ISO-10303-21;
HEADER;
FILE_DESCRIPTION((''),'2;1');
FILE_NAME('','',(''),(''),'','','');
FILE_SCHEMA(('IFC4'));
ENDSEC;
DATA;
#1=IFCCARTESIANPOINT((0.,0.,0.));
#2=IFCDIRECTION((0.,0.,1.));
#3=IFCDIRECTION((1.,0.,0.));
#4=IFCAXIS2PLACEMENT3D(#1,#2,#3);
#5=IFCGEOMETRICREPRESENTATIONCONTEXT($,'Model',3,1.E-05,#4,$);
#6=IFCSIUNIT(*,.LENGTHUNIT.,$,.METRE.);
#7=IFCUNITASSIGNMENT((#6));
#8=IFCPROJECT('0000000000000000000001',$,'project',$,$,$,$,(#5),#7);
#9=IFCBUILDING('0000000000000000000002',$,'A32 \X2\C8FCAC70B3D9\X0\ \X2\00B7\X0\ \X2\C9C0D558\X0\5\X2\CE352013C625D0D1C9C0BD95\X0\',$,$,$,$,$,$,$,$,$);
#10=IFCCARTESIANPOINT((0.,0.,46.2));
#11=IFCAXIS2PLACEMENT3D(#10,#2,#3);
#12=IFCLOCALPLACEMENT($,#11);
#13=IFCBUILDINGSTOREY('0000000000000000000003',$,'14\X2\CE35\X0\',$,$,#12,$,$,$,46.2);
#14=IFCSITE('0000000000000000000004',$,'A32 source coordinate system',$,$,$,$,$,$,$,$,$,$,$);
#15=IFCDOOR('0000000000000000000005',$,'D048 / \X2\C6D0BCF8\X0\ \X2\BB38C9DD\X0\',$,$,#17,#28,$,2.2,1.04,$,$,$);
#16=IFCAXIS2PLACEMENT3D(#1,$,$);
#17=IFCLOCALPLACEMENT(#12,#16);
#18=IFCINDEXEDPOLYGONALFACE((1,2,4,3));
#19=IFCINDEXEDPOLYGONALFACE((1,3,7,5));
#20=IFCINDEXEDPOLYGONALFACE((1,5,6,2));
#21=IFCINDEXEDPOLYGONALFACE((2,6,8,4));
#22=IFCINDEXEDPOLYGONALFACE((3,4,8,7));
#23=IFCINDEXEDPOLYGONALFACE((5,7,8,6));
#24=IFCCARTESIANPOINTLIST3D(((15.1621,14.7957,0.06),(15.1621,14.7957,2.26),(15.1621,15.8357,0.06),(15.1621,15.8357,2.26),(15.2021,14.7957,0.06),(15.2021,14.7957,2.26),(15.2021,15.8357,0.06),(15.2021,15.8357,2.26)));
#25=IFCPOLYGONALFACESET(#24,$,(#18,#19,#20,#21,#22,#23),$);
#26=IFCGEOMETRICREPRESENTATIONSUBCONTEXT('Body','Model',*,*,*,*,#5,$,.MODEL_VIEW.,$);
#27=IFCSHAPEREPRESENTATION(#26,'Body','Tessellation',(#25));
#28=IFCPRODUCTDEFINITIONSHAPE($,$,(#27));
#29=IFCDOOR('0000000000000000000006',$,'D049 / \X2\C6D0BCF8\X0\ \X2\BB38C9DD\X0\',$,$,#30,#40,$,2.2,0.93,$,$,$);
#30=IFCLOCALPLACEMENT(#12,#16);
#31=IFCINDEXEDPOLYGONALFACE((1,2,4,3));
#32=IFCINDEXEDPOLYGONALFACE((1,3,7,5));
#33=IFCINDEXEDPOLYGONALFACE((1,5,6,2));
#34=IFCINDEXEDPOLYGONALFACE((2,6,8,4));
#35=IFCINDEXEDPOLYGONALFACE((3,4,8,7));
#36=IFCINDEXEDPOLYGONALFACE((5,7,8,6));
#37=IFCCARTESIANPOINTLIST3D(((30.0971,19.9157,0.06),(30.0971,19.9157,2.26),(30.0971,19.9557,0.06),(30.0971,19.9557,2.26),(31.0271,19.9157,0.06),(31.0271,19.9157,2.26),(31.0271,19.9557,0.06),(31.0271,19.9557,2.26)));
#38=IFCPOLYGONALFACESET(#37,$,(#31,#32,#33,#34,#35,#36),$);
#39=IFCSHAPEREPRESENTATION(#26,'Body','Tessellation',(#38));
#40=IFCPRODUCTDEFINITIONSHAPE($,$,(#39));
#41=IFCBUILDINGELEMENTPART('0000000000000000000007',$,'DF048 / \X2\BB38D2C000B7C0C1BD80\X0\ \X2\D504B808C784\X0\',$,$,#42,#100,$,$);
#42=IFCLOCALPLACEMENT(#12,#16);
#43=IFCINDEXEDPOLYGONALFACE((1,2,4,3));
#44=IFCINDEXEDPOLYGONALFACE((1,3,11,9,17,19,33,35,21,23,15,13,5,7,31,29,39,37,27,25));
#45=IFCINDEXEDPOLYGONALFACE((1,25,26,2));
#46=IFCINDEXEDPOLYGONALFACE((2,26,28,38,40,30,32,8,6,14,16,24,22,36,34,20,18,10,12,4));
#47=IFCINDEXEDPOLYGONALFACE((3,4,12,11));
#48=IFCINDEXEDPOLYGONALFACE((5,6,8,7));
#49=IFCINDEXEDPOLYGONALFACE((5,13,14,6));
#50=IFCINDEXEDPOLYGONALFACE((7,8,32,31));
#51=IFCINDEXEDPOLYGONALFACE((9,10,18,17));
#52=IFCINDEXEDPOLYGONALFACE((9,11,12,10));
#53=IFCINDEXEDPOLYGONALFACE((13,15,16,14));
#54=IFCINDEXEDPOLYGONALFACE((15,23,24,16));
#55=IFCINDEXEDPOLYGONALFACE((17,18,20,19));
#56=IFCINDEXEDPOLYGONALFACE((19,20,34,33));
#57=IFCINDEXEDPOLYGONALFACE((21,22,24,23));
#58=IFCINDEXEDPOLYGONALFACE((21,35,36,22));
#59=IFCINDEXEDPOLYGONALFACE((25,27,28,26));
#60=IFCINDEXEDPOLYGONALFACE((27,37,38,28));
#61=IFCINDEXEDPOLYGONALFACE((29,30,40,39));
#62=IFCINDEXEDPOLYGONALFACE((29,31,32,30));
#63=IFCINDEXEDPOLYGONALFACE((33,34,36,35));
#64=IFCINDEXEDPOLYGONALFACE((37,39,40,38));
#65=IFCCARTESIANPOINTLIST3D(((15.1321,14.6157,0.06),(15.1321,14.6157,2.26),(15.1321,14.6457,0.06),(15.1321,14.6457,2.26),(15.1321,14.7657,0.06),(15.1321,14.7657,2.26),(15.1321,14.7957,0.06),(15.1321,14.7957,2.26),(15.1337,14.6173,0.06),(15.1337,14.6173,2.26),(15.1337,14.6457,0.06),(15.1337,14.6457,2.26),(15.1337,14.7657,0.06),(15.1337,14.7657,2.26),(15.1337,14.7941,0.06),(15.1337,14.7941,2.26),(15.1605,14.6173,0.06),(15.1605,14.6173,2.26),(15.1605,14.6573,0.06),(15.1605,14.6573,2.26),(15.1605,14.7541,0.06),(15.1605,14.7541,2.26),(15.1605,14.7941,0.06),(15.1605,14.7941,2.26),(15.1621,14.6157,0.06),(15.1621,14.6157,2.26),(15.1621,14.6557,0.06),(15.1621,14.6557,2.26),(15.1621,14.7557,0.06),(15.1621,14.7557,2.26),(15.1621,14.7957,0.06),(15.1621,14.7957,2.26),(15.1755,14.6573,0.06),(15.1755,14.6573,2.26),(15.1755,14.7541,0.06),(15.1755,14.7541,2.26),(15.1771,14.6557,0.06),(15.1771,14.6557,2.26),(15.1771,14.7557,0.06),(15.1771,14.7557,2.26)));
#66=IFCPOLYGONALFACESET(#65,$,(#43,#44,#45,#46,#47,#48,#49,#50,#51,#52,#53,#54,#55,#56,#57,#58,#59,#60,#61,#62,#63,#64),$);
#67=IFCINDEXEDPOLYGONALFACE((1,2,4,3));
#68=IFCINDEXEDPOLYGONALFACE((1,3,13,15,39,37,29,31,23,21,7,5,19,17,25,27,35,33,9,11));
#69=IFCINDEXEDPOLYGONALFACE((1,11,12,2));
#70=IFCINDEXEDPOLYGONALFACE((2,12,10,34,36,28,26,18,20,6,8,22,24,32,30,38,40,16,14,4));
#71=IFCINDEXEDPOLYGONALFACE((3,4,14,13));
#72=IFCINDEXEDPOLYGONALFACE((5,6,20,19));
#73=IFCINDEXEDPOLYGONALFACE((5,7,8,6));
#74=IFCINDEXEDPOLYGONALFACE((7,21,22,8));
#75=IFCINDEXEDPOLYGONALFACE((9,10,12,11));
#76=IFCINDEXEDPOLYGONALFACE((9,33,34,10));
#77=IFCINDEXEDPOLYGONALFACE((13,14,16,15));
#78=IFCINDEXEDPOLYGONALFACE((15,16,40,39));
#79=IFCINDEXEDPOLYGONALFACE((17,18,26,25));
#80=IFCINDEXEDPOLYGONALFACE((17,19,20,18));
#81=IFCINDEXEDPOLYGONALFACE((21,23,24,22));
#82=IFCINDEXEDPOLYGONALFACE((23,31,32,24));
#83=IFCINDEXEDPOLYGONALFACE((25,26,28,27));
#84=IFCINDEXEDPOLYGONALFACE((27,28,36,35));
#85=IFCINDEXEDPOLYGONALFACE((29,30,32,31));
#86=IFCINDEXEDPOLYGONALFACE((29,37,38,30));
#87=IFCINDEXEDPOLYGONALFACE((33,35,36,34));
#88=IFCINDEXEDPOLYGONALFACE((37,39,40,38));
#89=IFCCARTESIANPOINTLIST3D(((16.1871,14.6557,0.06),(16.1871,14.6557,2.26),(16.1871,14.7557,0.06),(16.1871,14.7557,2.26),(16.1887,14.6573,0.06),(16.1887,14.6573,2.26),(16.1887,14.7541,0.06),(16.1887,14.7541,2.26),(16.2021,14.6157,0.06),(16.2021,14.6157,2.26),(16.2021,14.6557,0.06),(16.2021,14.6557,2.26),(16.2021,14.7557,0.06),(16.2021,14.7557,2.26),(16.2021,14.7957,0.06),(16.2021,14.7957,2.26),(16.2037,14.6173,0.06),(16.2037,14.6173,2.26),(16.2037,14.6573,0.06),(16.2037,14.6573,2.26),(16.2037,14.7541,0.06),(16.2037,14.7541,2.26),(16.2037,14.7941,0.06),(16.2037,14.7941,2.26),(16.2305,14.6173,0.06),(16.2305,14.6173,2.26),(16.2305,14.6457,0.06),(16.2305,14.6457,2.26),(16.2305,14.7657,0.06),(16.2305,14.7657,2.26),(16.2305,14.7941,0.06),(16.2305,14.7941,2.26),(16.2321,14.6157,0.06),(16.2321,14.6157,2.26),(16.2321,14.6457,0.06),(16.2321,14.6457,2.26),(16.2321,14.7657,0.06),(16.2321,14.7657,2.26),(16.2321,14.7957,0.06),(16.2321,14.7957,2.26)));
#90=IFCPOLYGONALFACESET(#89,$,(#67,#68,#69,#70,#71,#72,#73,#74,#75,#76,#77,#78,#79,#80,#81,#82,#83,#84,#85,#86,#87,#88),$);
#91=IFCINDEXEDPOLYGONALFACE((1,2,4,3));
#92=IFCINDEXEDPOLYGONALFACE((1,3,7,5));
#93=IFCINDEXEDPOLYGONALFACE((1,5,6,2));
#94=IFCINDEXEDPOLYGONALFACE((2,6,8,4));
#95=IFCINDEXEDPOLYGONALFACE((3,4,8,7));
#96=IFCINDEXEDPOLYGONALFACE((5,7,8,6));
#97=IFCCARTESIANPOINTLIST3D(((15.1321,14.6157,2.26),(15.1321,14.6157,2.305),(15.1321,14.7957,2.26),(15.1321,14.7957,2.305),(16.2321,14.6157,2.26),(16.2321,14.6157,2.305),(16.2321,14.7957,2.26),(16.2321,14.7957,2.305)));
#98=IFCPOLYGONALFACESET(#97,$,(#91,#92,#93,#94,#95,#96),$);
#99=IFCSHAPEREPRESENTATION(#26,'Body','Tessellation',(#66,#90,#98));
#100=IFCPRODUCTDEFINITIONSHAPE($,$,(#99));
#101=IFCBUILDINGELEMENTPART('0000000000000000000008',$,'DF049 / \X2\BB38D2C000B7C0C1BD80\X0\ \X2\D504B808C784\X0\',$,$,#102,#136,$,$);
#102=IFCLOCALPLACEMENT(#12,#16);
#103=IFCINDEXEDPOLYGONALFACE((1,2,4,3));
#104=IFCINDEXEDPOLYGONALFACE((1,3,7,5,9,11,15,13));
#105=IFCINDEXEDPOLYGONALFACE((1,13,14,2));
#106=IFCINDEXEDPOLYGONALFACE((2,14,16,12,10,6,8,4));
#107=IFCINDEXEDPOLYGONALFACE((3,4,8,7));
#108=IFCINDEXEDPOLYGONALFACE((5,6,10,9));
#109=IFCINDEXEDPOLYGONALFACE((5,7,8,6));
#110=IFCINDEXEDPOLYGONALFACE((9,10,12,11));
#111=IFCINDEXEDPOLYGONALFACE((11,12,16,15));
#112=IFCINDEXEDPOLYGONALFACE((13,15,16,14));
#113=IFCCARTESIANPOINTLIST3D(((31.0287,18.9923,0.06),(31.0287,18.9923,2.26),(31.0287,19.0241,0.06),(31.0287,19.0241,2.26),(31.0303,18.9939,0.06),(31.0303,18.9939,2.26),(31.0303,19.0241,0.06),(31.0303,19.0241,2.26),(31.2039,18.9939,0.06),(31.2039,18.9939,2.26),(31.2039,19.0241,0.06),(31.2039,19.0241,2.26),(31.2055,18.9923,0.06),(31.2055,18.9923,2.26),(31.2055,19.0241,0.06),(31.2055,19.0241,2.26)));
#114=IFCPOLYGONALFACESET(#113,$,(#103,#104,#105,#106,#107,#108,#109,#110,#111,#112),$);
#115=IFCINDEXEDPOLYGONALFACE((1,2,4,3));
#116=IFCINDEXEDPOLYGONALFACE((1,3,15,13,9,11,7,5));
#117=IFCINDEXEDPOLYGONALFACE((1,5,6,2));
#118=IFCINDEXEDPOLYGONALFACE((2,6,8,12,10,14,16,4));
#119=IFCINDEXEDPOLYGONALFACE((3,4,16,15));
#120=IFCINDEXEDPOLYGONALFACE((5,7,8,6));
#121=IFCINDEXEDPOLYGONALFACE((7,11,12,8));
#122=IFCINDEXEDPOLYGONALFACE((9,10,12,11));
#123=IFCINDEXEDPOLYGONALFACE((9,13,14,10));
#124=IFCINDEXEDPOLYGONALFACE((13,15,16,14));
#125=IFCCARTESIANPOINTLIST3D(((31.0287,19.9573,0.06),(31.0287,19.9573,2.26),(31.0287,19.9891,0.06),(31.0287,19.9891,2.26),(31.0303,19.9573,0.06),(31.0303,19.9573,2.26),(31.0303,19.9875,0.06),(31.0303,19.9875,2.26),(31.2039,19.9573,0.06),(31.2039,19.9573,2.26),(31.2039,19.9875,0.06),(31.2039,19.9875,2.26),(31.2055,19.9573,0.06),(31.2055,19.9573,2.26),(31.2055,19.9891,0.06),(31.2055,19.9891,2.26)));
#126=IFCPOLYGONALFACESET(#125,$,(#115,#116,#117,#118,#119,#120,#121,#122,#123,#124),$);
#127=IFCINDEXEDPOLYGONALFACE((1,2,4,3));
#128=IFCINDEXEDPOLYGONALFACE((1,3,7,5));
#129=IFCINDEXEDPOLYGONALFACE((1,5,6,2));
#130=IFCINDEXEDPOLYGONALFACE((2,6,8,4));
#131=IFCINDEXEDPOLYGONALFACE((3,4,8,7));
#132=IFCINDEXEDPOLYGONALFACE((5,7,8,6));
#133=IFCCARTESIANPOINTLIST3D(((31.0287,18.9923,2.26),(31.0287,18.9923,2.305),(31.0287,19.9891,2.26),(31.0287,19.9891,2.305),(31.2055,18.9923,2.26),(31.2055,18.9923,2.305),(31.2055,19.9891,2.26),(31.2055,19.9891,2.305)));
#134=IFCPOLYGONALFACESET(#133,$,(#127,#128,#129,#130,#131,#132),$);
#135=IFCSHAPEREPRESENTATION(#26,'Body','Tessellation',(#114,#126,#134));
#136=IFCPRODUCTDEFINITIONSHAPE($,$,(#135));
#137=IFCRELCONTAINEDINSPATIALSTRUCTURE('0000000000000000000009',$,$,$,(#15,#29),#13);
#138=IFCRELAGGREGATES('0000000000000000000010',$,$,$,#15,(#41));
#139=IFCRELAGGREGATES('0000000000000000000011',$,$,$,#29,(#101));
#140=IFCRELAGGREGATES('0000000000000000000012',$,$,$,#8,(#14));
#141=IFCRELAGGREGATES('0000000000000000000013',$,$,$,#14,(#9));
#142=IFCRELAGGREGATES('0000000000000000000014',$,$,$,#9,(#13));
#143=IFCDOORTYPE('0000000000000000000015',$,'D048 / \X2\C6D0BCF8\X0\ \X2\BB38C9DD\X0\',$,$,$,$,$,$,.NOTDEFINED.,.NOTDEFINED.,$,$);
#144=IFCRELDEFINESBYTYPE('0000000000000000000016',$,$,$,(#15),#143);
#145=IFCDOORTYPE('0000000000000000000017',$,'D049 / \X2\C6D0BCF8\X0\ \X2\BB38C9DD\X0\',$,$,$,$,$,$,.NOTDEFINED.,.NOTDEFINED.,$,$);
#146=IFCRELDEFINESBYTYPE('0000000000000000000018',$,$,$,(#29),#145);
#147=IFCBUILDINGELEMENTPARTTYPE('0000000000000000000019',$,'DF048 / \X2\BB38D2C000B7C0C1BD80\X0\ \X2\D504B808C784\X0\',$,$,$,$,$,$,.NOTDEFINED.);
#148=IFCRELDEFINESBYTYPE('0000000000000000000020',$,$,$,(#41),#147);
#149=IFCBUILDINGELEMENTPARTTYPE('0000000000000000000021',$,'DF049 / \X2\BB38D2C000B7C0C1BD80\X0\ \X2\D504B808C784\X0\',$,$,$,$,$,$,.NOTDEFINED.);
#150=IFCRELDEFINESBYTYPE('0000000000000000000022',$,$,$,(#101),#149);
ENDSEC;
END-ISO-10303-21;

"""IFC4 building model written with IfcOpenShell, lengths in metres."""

from ifc_helpers import new_model, si_unit, frame, origin, origin_with_axes, place, context, subcontext, project, spatial, polyline, outline, extrude, source, transform, mapped, type_object, type_shapes, element, aggregate, save


model = new_model("IFC4")

# Units and contexts
model_context = context("Model", 3, precision=1e-05, world=origin_with_axes())
body_context = subcontext(model_context, "Body", "Model", "MODEL_VIEW")
ifc_project = project(units=[si_unit("LENGTHUNIT", "METRE")], contexts=[model_context])

# Site, building, storey
storey_placement = place(None, frame((0.0, 0.0, 46.2), z_axis=(0.0, 0.0, 1.0), x_axis=(1.0, 0.0, 0.0)))
site = spatial("IfcSite", under=ifc_project, Name="A32 source coordinate system")
building = spatial("IfcBuilding", under=site, Name="A32 주거동 · 지하5층–옥탑지붕")
storey = spatial("IfcBuildingStorey", under=building, at=storey_placement, Name="14층", Elevation=46.2)

# Doors
door_type_1 = type_object("IfcDoorType", Name="D048 / 원본 문짝", OperationType="NOTDEFINED", PredefinedType="NOTDEFINED")
shared_shape_1 = source(origin(), body_context, "Body", "SweptSolid", [
    extrude(outline(polyline([(15.2021, 15.8357), (15.2021, 14.7957), (15.1621, 14.7957), (15.1621, 15.8357), (15.2021, 15.8357)])), frame((0.0, 0.0, 0.06)), (0.0, 0.0, 1.0), 2.2),
])
type_shapes(door_type_1, [shared_shape_1])
door_1_placement = place(storey_placement, origin_with_axes())
door_1 = element("IfcDoor", 1, at=door_1_placement, inside=storey, type_object=door_type_1, Name="D048 / 원본 문짝", OverallHeight=2.2, OverallWidth=1.04, context=body_context, shape_type="MappedRepresentation", body=[
    mapped(shared_shape_1, transform((0.0, 0.0, 0.0), scale=1.0)),
])
door_type_2 = type_object("IfcDoorType", Name="D049 / 원본 문짝", OperationType="NOTDEFINED", PredefinedType="NOTDEFINED")
shared_shape_2 = source(origin(), body_context, "Body", "SweptSolid", [
    extrude(outline(polyline([(31.0271, 19.9557), (31.0271, 19.9157), (30.0971, 19.9157), (30.0971, 19.9557), (31.0271, 19.9557)])), frame((0.0, 0.0, 0.06)), (0.0, 0.0, 1.0), 2.2),
])
type_shapes(door_type_2, [shared_shape_2])
door_2_placement = place(storey_placement, origin_with_axes())
door_2 = element("IfcDoor", 2, at=door_2_placement, inside=storey, type_object=door_type_2, Name="D049 / 원본 문짝", OverallHeight=2.2, OverallWidth=0.93, context=body_context, shape_type="MappedRepresentation", body=[
    mapped(shared_shape_2, transform((0.0, 0.0, 0.0), scale=1.0)),
])

# Building element parts
building_element_part_type_1 = type_object("IfcBuildingElementPartType", Name="DF048 / 문틀·상부 프레임", PredefinedType="NOTDEFINED")
shared_shape_3 = source(origin(), body_context, "Body", "SweptSolid", [
    extrude(outline(polyline([(15.1321, 14.7657), (15.1321, 14.7957), (15.1621, 14.7957), (15.1621, 14.7557), (15.1771, 14.7557), (15.1771, 14.6557), (15.1621, 14.6557), (15.1621, 14.6157), (15.1321, 14.6157), (15.1321, 14.6457), (15.1337, 14.6457), (15.1337, 14.6173), (15.1605, 14.6173), (15.1605, 14.6573), (15.1755, 14.6573), (15.1755, 14.7541), (15.1605, 14.7541), (15.1605, 14.7941), (15.1337, 14.7941), (15.1337, 14.7657), (15.1321, 14.7657)])), frame((0.0, 0.0, 0.06)), (0.0, 0.0, 1.0), 2.2),
    extrude(outline(polyline([(16.2305, 14.7941), (16.2037, 14.7941), (16.2037, 14.7541), (16.1887, 14.7541), (16.1887, 14.6573), (16.2037, 14.6573), (16.2037, 14.6173), (16.2305, 14.6173), (16.2305, 14.6457), (16.2321, 14.6457), (16.2321, 14.6157), (16.2021, 14.6157), (16.2021, 14.6557), (16.1871, 14.6557), (16.1871, 14.7557), (16.2021, 14.7557), (16.2021, 14.7957), (16.2321, 14.7957), (16.2321, 14.7657), (16.2305, 14.7657), (16.2305, 14.7941)])), frame((0.0, 0.0, 0.06)), (0.0, 0.0, 1.0), 2.2),
    extrude(outline(polyline([(15.1321, 14.6157), (15.1321, 14.7957), (16.2321, 14.7957), (16.2321, 14.6157), (15.1321, 14.6157)])), frame((0.0, 0.0, 2.26)), (0.0, 0.0, 1.0), 0.045),
])
type_shapes(building_element_part_type_1, [shared_shape_3])
building_element_part_1_placement = place(door_1_placement, origin_with_axes())
building_element_part_1 = element("IfcBuildingElementPart", 3, at=building_element_part_1_placement, type_object=building_element_part_type_1, Name="DF048 / 문틀·상부 프레임", context=body_context, shape_type="MappedRepresentation", body=[
    mapped(shared_shape_3, transform((0.0, 0.0, 0.0), scale=1.0)),
])
aggregate(door_1, [building_element_part_1])
building_element_part_type_2 = type_object("IfcBuildingElementPartType", Name="DF049 / 문틀·상부 프레임", PredefinedType="NOTDEFINED")
shared_shape_4 = source(origin(), body_context, "Body", "SweptSolid", [
    extrude(outline(polyline([(31.0303, 19.0241), (31.0303, 18.9939), (31.2039, 18.9939), (31.2039, 19.0241), (31.2055, 19.0241), (31.2055, 18.9923), (31.0287, 18.9923), (31.0287, 19.0241), (31.0303, 19.0241)])), frame((0.0, 0.0, 0.06)), (0.0, 0.0, 1.0), 2.2),
    extrude(outline(polyline([(31.0287, 19.9891), (31.2055, 19.9891), (31.2055, 19.9573), (31.2039, 19.9573), (31.2039, 19.9875), (31.0303, 19.9875), (31.0303, 19.9573), (31.0287, 19.9573), (31.0287, 19.9891)])), frame((0.0, 0.0, 0.06)), (0.0, 0.0, 1.0), 2.2),
    extrude(outline(polyline([(31.0287, 18.9923), (31.0287, 19.9891), (31.2055, 19.9891), (31.2055, 18.9923), (31.0287, 18.9923)])), frame((0.0, 0.0, 2.26)), (0.0, 0.0, 1.0), 0.045),
])
type_shapes(building_element_part_type_2, [shared_shape_4])
building_element_part_2_placement = place(door_2_placement, origin_with_axes())
building_element_part_2 = element("IfcBuildingElementPart", 4, at=building_element_part_2_placement, type_object=building_element_part_type_2, Name="DF049 / 문틀·상부 프레임", context=body_context, shape_type="MappedRepresentation", body=[
    mapped(shared_shape_4, transform((0.0, 0.0, 0.0), scale=1.0)),
])
aggregate(door_2, [building_element_part_2])

save(model, "model.ifc")
